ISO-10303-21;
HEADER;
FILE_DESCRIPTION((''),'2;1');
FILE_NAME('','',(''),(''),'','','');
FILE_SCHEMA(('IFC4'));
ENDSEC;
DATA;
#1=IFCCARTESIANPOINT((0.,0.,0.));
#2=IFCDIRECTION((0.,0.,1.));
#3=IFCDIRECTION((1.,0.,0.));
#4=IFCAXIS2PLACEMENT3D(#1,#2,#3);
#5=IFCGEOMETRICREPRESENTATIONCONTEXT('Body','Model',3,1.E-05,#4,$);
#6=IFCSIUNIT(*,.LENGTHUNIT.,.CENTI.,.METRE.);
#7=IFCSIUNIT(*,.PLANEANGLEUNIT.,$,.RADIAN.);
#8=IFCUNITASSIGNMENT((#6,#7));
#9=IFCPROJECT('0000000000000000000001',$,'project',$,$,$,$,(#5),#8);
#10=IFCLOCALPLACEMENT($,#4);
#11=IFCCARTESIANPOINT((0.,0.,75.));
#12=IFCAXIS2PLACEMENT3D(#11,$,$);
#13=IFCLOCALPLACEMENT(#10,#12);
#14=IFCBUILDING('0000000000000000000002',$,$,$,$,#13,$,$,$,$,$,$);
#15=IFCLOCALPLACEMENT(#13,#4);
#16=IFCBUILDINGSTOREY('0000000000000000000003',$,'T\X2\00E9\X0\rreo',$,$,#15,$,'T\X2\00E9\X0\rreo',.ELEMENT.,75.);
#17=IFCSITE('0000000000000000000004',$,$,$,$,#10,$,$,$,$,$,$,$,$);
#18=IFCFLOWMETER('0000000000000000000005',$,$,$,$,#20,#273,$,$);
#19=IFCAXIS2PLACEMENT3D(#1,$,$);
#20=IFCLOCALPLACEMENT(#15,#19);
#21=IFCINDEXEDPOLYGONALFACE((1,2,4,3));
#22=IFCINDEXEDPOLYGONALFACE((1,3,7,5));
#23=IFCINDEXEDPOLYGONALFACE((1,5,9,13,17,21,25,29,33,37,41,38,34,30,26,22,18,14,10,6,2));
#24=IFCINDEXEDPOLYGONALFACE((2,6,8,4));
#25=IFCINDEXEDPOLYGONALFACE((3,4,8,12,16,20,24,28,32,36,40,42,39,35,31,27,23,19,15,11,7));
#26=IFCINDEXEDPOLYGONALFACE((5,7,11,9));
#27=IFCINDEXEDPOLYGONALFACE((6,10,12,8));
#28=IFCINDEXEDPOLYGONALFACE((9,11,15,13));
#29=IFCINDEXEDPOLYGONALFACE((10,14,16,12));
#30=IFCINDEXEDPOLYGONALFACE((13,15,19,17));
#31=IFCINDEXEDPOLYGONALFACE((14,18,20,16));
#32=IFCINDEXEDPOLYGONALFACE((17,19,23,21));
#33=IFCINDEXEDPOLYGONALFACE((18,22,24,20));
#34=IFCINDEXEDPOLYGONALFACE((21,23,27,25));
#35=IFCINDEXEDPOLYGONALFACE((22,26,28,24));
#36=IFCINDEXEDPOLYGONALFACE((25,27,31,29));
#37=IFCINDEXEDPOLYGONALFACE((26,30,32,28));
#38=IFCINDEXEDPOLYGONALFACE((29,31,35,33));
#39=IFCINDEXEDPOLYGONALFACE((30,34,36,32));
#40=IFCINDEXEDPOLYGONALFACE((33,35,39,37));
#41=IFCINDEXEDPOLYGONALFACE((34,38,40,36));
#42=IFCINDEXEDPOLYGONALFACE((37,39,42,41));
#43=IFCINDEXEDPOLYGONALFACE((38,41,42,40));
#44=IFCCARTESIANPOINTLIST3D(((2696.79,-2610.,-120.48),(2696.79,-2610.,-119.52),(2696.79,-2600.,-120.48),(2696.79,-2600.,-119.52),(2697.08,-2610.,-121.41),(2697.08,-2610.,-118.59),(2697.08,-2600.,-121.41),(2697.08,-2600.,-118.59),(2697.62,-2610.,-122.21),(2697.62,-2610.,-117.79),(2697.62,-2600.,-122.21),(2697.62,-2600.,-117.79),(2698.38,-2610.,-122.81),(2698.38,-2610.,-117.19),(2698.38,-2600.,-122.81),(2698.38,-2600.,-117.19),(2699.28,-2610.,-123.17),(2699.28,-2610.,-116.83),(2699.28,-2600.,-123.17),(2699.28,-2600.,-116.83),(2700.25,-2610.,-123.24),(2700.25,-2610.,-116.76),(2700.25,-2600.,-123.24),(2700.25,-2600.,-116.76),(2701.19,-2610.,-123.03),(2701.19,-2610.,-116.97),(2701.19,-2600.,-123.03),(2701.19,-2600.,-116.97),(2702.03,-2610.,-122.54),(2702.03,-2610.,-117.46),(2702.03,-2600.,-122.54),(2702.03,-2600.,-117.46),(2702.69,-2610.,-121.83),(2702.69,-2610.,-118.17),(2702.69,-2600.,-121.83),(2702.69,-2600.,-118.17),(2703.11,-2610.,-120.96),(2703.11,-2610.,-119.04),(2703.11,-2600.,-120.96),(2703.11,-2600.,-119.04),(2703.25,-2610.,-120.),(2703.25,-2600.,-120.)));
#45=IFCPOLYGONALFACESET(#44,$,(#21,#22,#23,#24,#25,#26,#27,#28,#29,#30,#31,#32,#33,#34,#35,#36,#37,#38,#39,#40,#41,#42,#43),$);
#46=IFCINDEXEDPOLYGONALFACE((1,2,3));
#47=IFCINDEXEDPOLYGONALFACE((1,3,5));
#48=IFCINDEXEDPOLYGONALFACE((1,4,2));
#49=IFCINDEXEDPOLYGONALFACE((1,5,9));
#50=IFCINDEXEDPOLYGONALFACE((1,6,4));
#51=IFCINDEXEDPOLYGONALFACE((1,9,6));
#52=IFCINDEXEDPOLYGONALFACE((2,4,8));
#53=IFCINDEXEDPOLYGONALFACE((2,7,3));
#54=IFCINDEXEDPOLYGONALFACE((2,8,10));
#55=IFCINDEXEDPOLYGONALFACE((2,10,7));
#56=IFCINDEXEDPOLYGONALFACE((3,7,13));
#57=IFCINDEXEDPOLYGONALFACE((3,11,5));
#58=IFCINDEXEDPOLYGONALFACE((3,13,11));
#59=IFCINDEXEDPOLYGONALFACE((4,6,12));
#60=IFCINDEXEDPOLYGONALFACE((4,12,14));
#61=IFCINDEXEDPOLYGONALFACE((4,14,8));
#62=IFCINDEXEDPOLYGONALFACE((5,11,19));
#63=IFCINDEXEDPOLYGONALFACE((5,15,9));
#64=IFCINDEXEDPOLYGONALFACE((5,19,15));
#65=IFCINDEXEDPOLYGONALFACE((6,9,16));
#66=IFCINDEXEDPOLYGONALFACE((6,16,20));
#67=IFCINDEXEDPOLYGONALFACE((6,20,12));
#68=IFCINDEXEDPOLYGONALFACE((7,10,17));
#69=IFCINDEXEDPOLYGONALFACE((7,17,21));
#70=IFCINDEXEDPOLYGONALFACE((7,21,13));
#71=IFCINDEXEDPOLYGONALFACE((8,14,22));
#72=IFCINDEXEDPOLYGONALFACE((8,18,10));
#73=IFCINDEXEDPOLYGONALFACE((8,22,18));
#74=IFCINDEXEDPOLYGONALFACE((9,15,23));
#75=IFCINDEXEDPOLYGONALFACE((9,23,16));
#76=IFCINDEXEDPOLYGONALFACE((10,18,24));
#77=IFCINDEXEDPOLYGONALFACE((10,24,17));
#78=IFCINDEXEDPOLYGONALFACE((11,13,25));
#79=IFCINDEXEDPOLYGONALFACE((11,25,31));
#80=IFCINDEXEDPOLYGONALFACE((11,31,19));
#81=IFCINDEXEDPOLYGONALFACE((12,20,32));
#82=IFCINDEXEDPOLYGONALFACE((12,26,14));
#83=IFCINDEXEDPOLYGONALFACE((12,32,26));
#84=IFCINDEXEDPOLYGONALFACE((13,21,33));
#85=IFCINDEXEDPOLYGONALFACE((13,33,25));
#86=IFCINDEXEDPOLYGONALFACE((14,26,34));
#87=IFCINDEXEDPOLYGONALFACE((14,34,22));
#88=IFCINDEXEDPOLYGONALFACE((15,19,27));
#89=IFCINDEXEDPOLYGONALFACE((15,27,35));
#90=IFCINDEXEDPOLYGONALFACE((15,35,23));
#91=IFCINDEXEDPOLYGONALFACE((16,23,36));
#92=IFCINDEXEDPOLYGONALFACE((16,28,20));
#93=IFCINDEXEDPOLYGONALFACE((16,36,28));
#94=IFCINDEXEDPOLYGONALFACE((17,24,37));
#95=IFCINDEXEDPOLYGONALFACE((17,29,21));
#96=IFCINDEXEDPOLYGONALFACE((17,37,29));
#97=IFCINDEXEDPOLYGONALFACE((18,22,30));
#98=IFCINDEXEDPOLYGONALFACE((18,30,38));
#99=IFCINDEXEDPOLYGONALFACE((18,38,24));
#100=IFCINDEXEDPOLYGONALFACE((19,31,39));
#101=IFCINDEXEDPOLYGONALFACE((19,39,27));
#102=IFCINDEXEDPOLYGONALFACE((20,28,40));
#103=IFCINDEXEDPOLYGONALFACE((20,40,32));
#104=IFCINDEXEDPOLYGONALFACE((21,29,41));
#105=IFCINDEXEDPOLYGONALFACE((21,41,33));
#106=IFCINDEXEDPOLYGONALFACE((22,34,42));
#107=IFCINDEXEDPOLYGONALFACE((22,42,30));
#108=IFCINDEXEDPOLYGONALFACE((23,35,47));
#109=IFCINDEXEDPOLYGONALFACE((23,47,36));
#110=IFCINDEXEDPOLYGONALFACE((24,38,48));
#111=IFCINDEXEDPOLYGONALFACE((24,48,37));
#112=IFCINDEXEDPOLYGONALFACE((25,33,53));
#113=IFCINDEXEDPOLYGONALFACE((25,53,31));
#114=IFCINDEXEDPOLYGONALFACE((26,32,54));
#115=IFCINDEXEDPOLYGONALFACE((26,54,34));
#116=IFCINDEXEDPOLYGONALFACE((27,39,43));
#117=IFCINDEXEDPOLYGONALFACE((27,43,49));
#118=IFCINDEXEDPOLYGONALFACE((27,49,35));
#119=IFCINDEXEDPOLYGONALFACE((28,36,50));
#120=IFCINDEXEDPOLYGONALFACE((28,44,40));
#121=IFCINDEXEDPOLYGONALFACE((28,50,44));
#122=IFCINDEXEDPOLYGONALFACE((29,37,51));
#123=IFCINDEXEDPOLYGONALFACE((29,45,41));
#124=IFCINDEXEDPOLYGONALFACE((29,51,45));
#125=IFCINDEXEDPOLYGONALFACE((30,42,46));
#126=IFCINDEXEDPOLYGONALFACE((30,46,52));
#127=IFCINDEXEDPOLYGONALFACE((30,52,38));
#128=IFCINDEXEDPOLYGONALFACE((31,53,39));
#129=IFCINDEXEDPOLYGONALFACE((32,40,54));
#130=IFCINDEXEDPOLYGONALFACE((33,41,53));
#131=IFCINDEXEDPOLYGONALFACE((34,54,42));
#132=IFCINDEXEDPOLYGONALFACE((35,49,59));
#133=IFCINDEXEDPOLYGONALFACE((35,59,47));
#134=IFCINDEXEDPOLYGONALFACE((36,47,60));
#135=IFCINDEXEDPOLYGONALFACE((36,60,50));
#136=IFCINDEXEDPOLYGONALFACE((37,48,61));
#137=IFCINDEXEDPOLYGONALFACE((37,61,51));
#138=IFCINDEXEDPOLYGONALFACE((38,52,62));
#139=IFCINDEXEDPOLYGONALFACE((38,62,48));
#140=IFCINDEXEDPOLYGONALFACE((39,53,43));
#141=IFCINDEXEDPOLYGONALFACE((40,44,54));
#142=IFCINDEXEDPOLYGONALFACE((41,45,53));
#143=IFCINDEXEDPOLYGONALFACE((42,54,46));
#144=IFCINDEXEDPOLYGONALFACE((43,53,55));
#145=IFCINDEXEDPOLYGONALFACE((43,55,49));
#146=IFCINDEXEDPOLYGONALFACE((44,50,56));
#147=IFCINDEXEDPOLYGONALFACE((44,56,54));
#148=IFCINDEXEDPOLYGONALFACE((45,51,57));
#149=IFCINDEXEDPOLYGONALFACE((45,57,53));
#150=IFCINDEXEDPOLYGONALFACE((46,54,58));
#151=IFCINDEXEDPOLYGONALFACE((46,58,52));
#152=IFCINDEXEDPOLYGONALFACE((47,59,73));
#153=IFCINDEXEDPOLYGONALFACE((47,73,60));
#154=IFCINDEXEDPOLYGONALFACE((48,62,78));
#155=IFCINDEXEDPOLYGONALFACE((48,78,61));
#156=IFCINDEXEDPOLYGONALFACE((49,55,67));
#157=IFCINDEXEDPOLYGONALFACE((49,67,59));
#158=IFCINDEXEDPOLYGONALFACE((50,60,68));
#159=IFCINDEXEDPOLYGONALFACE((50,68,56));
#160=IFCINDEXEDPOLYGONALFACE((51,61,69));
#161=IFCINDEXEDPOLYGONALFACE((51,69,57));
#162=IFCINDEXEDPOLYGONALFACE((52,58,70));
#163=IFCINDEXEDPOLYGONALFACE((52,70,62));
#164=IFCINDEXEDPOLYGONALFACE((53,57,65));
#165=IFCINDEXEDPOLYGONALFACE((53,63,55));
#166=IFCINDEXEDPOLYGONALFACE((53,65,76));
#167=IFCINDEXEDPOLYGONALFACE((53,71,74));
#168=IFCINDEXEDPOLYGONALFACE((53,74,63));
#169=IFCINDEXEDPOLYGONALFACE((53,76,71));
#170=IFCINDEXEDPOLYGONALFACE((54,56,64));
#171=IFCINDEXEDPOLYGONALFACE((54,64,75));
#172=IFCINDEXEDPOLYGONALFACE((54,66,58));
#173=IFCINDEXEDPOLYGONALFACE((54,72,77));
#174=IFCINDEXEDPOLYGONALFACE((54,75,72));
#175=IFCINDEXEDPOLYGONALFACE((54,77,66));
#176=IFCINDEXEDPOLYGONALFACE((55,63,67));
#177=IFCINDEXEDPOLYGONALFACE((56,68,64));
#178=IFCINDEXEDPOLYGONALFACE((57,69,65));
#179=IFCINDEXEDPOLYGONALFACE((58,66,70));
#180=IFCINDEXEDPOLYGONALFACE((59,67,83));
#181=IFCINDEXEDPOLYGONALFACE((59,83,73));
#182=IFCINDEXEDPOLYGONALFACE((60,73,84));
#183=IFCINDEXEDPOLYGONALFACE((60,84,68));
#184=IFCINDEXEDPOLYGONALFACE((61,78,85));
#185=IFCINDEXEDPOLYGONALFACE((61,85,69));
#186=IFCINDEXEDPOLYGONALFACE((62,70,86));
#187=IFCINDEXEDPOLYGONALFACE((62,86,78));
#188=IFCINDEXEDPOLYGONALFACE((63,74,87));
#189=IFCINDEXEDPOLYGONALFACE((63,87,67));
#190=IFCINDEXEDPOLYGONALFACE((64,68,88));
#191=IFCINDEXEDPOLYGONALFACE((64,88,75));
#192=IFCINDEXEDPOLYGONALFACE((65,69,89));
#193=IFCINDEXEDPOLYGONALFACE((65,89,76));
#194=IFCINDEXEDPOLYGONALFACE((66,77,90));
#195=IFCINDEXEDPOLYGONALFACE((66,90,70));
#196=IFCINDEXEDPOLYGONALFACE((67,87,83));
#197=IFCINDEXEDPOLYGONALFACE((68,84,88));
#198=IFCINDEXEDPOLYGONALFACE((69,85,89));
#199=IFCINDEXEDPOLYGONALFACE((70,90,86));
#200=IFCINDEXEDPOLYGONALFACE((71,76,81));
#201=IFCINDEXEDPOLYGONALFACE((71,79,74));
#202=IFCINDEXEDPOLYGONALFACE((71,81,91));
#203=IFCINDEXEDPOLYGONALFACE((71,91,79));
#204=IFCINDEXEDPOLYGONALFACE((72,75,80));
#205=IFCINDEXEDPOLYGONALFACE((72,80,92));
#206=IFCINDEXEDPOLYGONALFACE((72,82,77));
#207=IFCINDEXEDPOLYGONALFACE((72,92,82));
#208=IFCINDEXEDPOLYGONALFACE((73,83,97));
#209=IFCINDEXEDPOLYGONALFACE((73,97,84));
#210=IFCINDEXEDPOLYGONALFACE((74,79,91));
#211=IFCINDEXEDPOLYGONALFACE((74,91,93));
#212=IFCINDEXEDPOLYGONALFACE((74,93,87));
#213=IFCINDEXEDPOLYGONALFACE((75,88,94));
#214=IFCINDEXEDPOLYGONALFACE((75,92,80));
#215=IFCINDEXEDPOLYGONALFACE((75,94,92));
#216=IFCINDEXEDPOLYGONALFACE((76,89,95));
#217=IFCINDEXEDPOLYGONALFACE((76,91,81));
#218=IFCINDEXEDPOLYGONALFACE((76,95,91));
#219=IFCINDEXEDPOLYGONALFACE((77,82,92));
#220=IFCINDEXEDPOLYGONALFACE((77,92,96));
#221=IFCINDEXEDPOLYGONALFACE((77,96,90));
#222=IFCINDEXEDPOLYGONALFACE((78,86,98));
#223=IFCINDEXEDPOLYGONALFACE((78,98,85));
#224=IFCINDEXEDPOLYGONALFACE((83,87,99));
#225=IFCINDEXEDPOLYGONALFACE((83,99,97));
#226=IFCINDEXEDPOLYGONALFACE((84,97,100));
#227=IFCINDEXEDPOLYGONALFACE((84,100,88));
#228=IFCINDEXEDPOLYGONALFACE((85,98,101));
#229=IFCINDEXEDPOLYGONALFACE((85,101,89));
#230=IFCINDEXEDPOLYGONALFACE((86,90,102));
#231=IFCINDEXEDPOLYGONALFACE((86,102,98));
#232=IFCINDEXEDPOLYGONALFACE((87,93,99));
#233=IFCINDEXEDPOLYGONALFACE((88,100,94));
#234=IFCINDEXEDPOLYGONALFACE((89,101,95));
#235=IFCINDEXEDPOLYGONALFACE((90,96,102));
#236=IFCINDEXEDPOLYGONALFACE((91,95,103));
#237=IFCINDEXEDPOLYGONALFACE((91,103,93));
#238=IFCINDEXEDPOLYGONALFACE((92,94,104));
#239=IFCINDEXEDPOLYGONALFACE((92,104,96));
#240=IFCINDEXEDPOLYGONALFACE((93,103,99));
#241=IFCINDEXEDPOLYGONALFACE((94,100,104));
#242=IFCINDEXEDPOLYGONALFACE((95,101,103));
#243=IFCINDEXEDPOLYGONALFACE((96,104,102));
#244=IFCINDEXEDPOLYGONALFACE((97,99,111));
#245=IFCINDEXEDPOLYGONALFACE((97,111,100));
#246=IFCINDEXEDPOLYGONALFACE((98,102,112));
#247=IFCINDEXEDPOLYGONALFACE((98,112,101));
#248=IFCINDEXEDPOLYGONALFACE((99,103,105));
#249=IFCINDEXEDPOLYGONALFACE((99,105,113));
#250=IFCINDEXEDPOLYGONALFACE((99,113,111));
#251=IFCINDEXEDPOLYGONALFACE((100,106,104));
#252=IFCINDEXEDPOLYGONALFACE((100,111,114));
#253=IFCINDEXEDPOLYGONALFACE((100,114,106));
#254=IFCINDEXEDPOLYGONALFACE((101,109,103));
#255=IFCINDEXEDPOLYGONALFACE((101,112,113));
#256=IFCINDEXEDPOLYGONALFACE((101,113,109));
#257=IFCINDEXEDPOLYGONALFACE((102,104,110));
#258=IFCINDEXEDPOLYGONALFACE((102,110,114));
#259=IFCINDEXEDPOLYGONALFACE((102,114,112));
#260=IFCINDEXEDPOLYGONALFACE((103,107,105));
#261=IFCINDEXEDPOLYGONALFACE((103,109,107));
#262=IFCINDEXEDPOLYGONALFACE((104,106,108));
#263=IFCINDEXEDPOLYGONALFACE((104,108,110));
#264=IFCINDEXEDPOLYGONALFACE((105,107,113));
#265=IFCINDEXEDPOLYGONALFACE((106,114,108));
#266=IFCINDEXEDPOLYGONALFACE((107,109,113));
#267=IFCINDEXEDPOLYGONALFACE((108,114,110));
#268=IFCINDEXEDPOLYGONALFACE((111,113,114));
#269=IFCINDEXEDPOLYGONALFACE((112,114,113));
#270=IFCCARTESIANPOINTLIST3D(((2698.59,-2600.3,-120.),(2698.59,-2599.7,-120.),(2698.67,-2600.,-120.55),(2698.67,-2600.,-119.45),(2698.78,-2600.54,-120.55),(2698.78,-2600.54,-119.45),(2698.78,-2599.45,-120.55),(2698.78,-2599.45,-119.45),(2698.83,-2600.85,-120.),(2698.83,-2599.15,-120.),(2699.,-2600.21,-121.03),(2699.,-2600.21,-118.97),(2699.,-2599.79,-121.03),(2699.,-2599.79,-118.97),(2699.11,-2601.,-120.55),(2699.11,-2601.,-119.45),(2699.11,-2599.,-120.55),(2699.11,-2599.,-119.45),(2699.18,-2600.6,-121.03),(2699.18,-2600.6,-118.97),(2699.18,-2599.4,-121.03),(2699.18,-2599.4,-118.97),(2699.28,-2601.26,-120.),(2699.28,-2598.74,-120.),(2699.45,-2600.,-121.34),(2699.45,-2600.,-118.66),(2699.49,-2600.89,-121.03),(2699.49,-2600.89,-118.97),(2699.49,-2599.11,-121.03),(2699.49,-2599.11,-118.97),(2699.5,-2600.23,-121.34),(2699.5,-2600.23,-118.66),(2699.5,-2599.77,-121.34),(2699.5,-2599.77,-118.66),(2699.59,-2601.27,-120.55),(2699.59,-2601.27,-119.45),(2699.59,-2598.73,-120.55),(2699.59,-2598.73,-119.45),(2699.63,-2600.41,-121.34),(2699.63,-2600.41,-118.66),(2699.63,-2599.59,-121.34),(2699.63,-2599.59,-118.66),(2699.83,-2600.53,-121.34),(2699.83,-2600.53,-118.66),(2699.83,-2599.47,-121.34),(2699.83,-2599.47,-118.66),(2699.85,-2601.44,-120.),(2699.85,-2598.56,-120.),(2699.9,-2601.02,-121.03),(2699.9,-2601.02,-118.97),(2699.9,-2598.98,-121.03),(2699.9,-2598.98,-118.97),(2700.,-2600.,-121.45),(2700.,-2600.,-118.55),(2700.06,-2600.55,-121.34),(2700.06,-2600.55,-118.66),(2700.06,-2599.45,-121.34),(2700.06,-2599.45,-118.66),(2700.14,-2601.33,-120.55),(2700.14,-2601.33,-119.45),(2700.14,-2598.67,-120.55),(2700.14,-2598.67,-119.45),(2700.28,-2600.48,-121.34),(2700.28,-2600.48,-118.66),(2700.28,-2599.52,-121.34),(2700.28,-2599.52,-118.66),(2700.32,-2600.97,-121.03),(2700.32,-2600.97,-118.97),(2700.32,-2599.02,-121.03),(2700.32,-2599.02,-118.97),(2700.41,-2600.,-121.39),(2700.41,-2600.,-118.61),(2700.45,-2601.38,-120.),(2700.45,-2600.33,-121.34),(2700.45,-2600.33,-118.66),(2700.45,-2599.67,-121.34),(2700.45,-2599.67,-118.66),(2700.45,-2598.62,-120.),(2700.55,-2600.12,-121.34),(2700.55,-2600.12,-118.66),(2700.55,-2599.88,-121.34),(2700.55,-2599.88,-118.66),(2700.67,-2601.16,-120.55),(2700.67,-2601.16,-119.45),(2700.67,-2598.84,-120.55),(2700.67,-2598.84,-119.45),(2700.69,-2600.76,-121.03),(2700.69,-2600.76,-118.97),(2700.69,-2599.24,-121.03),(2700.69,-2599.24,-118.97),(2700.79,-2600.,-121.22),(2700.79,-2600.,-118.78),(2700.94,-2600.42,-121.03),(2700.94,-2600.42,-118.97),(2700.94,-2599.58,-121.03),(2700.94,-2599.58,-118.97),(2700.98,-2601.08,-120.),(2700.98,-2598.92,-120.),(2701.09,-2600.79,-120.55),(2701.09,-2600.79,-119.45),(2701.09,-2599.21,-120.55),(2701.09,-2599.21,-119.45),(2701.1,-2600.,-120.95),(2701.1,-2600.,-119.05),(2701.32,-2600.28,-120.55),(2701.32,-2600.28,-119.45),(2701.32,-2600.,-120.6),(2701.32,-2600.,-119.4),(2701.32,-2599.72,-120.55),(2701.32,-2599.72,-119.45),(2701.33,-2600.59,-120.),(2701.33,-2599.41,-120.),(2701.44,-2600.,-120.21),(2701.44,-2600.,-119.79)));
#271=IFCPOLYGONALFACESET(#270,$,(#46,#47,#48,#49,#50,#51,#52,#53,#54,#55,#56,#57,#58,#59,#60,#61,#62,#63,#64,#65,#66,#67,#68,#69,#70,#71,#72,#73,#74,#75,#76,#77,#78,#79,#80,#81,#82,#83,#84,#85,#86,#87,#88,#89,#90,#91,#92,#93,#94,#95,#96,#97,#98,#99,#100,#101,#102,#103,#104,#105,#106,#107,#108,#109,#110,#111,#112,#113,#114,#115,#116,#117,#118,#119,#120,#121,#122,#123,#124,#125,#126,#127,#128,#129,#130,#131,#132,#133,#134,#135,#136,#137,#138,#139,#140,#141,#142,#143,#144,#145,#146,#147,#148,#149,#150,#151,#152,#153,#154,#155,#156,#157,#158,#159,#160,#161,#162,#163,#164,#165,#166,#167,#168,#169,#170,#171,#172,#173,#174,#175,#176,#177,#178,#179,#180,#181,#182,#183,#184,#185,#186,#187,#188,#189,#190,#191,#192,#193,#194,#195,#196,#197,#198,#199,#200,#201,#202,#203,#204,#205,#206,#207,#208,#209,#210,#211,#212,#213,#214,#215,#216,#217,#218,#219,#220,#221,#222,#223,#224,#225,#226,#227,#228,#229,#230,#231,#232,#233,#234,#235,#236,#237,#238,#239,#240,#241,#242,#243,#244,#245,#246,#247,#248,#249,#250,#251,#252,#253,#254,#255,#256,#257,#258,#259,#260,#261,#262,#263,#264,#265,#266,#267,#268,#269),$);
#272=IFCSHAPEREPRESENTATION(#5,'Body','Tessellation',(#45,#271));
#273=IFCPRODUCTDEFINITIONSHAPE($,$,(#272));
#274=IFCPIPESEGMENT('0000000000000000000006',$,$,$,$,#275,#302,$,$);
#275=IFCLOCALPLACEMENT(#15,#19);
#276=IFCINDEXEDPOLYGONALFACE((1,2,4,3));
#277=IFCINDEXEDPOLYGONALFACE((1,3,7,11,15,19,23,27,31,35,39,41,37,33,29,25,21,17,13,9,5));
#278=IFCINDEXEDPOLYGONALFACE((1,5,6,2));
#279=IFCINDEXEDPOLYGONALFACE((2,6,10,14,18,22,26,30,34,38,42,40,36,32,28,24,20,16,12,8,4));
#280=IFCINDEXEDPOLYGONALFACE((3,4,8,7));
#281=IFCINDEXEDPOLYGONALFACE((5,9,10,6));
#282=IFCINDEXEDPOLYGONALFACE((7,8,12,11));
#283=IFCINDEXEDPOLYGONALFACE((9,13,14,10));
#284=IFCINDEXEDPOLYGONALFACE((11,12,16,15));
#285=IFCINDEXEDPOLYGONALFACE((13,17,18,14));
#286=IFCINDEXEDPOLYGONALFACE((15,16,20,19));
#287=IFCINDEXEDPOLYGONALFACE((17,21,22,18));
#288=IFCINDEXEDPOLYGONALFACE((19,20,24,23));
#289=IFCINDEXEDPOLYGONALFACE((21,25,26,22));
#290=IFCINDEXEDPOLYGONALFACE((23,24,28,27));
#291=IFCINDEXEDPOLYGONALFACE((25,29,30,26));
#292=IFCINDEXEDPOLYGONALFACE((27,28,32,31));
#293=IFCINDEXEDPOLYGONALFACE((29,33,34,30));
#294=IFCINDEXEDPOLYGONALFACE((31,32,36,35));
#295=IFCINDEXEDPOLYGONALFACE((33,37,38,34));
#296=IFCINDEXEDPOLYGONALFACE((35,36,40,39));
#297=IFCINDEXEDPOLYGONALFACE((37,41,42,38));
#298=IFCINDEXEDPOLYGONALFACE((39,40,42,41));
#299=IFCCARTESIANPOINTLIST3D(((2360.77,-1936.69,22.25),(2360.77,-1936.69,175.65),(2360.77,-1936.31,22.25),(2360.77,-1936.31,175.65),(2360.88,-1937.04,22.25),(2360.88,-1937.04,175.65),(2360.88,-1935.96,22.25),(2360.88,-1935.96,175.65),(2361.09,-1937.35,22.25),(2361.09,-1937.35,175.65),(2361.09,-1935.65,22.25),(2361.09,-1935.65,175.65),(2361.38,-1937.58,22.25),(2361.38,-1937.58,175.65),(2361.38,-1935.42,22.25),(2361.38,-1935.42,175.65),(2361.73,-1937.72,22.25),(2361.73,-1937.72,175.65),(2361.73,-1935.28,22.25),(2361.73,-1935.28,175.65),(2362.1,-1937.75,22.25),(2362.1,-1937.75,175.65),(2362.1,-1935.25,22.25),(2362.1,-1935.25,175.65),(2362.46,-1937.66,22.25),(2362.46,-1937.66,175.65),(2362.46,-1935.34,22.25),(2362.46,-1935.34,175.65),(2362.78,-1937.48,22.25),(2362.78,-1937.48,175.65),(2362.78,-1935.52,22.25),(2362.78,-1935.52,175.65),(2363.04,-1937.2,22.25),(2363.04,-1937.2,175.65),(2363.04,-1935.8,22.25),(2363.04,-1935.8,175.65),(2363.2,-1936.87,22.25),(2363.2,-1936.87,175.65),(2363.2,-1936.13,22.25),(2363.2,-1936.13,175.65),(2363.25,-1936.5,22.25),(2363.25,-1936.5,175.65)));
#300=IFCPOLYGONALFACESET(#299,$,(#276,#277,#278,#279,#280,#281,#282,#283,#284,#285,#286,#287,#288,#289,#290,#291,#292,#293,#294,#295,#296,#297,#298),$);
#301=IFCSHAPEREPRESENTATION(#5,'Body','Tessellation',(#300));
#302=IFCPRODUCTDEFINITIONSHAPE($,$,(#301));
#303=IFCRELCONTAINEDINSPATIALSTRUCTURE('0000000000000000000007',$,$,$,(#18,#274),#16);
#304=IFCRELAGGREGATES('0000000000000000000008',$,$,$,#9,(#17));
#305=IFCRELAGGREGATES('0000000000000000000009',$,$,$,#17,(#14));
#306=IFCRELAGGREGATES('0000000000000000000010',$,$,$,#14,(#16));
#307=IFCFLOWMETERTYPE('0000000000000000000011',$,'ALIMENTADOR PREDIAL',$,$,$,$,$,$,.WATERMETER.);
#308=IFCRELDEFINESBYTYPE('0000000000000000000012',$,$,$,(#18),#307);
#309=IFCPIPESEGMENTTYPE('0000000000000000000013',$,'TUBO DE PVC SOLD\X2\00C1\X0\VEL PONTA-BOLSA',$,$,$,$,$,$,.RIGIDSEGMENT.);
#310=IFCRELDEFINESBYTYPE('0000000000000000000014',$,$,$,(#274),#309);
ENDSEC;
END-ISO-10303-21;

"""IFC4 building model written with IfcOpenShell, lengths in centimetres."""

from ifc_helpers import new_model, entity, si_unit, frame, origin_with_axes, origin_2d_with_axis, place, context, project, spatial, circle, extrude, type_object, element, save


model = new_model("IFC4")

# Units and contexts
model_context = context("Model", 3, precision=1e-05, world=origin_with_axes(), identifier="Body")
ifc_project = project(units=[si_unit("LENGTHUNIT", "METRE", prefix="CENTI"), si_unit("PLANEANGLEUNIT", "RADIAN")], contexts=[model_context])

# Site, building, storey
site_placement = place(None, origin_with_axes())
site = spatial("IfcSite", under=ifc_project, at=site_placement)
building_placement = place(site_placement, frame((0.0, 0.0, 75.0)))
building = spatial("IfcBuilding", under=site, at=building_placement)
storey_placement = place(building_placement, origin_with_axes())
storey = spatial("IfcBuildingStorey", under=building, at=storey_placement, Name="Térreo", LongName="Térreo", CompositionType="ELEMENT", Elevation=75.0)

# Flow meter
flow_meter_type = type_object("IfcFlowMeterType", Name="ALIMENTADOR PREDIAL", PredefinedType="WATERMETER")
flow_meter_placement = place(storey_placement, frame((2700.0, -2604.27, -116.75), z_axis=(0.0, 0.0, 1.0), x_axis=(1.0, 0.0, 0.0)))
element("IfcFlowMeter", 1, at=flow_meter_placement, inside=storey, type_object=flow_meter_type, context=model_context, shape_type="SolidModel", body=[
    extrude(circle(Radius=3.25, at=origin_2d_with_axis()), frame((0.0, -5.72, -3.25), z_axis=(0.0, 1.0, 0.0), x_axis=(1.0, 0.0, 0.0)), (0.0, 0.0, 1.0), 10.0),
    entity("IfcSphere", entity("IfcAxis2Placement3D", entity("IfcCartesianPoint", [0.0, 4.28, -3.25]), entity("IfcDirection", [0.0, 0.0, 1.0]), entity("IfcDirection", [1.0, 0.0, 0.0])), 1.45),
])

# Pipe segment
pipe_segment_type_1 = type_object("IfcPipeSegmentType", Name="TUBO DE PVC SOLDÁVEL PONTA-BOLSA", PredefinedType="RIGIDSEGMENT")
pipe_segment_1_placement = place(storey_placement, frame((2362.0, -1936.5, 175.65), z_axis=(0.0, 0.0, 1.0), x_axis=(1.0, 0.0, 0.0)))
element("IfcPipeSegment", 2, at=pipe_segment_1_placement, inside=storey, type_object=pipe_segment_type_1, context=model_context, shape_type="SolidModel", body=[
    extrude(circle(Radius=1.25, at=origin_2d_with_axis()), frame((0.0, 0.0, 0.0), z_axis=(0.0, 0.0, -1.0), x_axis=(1.0, 0.0, 0.0)), (0.0, 0.0, 1.0), 153.4),
])

save(model, "model.ifc")
